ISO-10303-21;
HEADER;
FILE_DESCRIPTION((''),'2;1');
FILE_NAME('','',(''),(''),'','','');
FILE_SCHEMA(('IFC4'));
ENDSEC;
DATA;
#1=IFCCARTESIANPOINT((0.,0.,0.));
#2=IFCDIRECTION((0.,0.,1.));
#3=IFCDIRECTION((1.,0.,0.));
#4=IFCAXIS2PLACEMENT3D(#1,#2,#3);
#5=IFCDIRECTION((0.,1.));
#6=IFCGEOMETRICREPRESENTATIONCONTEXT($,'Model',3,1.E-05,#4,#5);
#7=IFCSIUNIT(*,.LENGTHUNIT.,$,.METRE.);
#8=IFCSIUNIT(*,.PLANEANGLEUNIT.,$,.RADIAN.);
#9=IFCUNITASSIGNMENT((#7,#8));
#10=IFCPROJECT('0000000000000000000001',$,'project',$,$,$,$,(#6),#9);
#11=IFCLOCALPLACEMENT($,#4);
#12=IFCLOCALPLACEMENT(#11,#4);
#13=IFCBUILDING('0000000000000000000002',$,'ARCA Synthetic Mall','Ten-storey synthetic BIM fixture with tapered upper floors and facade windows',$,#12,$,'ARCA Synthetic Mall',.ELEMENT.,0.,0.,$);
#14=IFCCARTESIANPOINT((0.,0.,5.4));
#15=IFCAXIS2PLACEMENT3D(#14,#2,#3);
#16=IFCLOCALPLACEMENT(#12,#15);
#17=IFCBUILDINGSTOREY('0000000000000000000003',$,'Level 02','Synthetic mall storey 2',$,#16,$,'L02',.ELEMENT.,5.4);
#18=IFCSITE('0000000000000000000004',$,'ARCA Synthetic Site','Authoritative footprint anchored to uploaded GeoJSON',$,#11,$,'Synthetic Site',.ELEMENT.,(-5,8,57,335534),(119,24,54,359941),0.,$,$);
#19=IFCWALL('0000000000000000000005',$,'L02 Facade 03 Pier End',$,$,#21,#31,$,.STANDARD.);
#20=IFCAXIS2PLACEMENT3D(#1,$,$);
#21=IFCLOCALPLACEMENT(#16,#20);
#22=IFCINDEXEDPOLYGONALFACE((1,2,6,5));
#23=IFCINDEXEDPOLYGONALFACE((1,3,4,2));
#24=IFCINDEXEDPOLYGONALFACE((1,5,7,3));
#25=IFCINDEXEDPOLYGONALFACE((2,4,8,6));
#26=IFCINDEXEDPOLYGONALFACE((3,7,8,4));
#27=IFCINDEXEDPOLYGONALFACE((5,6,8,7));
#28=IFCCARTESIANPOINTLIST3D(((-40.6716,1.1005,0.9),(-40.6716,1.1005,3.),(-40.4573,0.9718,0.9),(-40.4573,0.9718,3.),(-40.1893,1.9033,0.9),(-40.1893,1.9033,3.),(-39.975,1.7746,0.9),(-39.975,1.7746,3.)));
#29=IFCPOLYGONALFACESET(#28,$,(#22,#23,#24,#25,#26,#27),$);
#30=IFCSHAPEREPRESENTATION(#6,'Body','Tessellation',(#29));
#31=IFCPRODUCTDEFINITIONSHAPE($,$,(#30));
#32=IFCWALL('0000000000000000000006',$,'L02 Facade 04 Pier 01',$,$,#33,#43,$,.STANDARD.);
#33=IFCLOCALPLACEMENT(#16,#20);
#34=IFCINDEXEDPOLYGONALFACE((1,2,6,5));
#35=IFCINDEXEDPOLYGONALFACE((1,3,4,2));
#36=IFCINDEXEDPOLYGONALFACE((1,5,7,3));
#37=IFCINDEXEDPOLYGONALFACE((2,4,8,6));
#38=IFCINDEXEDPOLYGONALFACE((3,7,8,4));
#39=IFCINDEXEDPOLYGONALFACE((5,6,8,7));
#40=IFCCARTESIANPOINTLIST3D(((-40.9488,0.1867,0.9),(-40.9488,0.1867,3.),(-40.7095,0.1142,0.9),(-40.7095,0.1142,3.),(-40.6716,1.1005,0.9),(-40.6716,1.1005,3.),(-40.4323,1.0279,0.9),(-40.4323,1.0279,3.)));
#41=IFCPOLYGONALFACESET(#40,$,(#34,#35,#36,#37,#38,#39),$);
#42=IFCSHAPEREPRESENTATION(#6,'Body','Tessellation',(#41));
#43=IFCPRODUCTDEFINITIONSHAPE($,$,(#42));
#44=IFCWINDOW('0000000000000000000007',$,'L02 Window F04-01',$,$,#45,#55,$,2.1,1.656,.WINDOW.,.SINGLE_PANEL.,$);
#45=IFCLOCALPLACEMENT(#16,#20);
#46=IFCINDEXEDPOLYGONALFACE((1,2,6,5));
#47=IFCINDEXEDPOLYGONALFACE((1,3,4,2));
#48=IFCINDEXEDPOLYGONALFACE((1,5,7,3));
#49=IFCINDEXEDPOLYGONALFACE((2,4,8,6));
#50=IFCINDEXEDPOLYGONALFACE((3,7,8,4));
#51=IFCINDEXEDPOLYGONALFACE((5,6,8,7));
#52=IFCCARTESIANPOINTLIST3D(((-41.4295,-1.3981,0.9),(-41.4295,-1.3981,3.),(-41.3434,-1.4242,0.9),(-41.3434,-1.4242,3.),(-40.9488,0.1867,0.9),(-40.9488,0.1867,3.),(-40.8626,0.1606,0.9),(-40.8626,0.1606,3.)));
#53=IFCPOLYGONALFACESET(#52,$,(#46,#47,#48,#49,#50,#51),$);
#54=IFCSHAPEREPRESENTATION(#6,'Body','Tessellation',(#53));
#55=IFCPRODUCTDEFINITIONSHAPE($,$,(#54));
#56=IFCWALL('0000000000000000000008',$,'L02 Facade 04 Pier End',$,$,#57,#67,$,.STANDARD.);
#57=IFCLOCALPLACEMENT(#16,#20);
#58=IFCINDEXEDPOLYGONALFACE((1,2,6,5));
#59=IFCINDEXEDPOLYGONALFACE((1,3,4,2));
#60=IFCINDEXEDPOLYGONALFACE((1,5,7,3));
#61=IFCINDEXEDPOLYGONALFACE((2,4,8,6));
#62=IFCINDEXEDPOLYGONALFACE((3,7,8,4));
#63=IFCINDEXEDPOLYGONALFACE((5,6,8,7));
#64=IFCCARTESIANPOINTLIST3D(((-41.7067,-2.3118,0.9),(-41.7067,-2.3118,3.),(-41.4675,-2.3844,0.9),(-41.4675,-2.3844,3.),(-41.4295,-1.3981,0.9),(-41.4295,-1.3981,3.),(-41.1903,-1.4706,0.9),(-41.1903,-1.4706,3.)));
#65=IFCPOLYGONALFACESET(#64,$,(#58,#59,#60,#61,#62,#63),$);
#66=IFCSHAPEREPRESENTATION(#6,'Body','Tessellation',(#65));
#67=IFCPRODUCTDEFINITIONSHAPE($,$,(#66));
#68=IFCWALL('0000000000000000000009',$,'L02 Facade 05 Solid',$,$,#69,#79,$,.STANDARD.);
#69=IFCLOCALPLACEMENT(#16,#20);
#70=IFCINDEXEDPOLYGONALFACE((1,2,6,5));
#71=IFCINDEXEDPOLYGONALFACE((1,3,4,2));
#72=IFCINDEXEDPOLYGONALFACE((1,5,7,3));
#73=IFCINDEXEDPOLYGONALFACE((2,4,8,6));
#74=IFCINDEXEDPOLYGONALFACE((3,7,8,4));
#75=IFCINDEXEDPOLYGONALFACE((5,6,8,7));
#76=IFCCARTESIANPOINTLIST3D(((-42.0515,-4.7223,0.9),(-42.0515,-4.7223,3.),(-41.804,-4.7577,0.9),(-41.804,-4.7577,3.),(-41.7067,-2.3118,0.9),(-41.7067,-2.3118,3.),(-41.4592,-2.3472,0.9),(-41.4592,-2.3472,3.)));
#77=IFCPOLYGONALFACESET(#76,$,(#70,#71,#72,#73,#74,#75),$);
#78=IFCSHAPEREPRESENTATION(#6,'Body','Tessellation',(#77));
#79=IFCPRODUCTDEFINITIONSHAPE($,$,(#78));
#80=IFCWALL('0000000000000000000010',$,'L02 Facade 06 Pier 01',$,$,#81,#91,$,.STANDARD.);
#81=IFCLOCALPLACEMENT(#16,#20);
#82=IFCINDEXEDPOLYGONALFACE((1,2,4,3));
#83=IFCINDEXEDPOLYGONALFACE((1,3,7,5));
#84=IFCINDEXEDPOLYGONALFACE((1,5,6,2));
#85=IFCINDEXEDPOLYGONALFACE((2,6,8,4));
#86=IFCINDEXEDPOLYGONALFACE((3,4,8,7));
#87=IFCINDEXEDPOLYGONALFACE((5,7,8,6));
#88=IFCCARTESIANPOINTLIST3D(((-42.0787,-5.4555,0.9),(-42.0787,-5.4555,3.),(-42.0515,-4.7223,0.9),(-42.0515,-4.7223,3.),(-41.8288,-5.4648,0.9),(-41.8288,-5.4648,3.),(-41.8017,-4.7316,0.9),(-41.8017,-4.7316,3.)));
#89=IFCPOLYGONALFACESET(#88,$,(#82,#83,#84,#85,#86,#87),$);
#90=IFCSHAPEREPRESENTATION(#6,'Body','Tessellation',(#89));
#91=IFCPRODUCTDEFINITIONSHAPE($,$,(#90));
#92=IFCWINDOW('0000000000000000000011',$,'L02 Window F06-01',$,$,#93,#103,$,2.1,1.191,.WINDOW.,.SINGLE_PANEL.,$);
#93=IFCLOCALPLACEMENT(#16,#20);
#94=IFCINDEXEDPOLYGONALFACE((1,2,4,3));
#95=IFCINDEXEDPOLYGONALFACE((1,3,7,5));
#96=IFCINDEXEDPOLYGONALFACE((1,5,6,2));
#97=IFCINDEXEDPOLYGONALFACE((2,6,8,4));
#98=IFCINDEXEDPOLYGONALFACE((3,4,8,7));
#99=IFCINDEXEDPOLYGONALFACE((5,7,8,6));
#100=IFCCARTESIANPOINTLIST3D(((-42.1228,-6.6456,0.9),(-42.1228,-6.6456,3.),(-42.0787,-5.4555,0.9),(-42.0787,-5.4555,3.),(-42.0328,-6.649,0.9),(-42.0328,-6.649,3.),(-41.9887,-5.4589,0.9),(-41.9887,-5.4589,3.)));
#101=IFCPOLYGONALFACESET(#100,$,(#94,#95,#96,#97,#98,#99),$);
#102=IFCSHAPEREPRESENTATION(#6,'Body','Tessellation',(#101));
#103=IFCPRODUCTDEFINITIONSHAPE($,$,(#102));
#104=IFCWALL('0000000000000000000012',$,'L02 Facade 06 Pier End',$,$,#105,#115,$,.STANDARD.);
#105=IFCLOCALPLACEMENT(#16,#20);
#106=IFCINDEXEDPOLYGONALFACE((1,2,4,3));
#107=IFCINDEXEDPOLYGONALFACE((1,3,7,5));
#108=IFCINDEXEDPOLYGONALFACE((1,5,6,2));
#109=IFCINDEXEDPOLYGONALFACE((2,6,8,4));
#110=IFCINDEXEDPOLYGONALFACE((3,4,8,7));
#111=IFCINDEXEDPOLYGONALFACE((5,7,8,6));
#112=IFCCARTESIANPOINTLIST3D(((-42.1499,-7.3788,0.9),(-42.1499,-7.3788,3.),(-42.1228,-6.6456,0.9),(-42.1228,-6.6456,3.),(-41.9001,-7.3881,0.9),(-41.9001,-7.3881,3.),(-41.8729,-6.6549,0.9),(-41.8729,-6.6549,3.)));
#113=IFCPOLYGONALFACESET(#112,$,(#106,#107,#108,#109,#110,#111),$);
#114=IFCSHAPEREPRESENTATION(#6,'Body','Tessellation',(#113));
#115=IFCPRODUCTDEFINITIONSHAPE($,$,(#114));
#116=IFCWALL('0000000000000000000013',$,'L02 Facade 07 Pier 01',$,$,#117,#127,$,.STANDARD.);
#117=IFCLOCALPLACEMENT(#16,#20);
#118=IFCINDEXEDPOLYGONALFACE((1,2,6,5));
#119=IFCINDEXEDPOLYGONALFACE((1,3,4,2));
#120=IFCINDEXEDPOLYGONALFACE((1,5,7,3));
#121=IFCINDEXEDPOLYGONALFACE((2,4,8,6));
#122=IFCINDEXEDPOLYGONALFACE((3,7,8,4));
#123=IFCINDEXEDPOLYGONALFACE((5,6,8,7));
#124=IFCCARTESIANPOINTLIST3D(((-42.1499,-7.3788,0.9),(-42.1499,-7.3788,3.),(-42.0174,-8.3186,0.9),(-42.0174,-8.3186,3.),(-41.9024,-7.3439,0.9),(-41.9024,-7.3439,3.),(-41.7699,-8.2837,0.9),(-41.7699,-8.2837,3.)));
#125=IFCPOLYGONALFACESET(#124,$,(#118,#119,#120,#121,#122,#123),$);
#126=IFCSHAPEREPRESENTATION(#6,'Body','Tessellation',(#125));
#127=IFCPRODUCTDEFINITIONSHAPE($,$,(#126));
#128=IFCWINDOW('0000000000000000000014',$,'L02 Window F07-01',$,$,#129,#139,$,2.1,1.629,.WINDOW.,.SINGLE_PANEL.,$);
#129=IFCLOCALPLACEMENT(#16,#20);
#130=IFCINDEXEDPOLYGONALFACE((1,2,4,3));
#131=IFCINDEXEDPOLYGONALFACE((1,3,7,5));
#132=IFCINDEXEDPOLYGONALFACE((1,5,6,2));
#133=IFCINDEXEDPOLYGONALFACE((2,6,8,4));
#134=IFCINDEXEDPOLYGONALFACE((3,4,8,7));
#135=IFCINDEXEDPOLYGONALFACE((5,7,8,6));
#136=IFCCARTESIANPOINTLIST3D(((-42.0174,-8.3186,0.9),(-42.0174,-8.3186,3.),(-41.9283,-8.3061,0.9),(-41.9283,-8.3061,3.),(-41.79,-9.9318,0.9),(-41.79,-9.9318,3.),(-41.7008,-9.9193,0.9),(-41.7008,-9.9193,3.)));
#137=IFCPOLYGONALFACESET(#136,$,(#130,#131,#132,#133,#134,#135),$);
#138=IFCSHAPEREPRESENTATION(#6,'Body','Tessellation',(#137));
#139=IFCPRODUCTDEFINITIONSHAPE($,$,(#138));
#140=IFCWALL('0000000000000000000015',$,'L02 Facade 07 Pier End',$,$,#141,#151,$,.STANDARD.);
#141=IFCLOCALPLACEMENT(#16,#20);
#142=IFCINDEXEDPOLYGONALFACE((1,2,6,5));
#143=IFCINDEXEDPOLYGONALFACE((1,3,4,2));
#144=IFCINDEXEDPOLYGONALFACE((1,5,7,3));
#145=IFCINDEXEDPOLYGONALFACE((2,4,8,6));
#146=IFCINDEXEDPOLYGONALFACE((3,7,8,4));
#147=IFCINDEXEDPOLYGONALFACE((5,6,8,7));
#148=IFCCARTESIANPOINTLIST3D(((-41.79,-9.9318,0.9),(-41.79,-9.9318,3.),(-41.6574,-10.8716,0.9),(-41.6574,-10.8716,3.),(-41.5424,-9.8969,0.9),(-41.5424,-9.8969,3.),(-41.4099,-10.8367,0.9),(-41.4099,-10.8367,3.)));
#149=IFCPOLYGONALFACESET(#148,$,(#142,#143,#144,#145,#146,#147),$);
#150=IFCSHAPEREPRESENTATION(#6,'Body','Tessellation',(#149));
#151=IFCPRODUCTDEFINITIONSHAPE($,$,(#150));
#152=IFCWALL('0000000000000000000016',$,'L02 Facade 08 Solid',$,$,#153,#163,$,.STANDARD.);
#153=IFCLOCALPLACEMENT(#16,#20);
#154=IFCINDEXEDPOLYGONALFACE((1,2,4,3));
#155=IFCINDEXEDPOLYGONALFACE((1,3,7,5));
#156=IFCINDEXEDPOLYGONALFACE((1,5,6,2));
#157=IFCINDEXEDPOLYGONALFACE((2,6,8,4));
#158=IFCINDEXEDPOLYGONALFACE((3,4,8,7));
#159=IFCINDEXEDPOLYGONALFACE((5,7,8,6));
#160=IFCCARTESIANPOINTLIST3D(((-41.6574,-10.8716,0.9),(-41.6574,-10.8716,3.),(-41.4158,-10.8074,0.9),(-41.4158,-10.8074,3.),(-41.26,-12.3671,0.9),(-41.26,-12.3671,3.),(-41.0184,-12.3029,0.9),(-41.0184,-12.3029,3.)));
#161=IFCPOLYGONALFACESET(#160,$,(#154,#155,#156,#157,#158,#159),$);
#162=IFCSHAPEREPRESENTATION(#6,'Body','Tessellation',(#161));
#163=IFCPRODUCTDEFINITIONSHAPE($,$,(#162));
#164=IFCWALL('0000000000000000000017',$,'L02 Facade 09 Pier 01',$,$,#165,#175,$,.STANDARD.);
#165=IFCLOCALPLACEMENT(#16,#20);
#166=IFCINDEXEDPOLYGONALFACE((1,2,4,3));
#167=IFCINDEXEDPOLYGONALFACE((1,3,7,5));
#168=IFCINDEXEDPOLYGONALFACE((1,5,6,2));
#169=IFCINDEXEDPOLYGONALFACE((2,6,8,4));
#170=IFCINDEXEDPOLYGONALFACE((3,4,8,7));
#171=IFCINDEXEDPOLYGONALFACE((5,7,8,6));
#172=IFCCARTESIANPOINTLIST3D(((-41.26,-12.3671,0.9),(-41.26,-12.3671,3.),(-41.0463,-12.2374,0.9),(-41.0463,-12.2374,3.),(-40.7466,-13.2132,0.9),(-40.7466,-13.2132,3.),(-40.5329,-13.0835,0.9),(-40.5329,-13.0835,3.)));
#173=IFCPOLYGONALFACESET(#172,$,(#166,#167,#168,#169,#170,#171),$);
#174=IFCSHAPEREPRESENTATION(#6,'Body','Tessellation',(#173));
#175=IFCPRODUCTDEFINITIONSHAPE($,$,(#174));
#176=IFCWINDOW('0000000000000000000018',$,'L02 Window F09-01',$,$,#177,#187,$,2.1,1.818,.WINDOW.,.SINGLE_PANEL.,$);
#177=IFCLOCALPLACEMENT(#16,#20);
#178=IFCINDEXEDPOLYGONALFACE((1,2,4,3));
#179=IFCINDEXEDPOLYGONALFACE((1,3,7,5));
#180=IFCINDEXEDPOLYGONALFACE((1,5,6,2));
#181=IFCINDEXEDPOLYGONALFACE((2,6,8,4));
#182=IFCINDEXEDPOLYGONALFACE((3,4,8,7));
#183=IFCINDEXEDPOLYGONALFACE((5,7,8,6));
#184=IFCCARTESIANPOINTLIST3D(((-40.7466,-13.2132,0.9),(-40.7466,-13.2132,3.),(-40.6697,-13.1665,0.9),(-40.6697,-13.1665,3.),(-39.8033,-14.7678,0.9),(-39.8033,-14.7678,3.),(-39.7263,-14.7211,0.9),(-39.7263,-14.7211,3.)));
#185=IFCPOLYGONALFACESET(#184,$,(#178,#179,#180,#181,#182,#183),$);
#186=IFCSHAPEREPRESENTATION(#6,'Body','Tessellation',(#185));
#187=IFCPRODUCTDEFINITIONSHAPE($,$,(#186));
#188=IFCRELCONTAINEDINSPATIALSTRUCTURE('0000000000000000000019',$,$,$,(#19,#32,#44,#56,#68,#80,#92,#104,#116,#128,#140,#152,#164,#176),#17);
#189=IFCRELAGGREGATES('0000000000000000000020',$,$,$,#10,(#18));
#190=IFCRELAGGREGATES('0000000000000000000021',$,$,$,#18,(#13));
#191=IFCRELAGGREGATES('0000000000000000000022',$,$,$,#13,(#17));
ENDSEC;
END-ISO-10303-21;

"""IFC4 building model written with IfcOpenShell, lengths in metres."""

from ifc_helpers import new_model, si_unit, direction, frame, origin_with_axes, place, context, project, spatial, polyline, outline, extrude, element, save


model = new_model("IFC4")

# Units and contexts
model_context = context("Model", 3, precision=1e-05, world=origin_with_axes(), true_north=direction((0.0, 1.0)))
ifc_project = project(units=[si_unit("LENGTHUNIT", "METRE"), si_unit("PLANEANGLEUNIT", "RADIAN")], contexts=[model_context])

# Site, building, storey
site_placement = place(None, origin_with_axes())
site = spatial("IfcSite", under=ifc_project, at=site_placement, Name="ARCA Synthetic Site", Description="Authoritative footprint anchored to uploaded GeoJSON", LongName="Synthetic Site", CompositionType="ELEMENT", RefLatitude=(-5, 8, 57, 335534), RefLongitude=(119, 24, 54, 359941), RefElevation=0.0)
building_placement = place(site_placement, origin_with_axes())
building = spatial("IfcBuilding", under=site, at=building_placement, Name="ARCA Synthetic Mall", Description="Ten-storey synthetic BIM fixture with tapered upper floors and facade windows", LongName="ARCA Synthetic Mall", CompositionType="ELEMENT", ElevationOfRefHeight=0.0, ElevationOfTerrain=0.0)
storey_placement = place(building_placement, frame((0.0, 0.0, 5.4), z_axis=(0.0, 0.0, 1.0), x_axis=(1.0, 0.0, 0.0)))
storey = spatial("IfcBuildingStorey", under=building, at=storey_placement, Name="Level 02", Description="Synthetic mall storey 2", LongName="L02", CompositionType="ELEMENT", Elevation=5.4)

# Walls
wall_1_placement = place(storey_placement, frame((0.0, 0.0, 0.9), z_axis=(0.0, 0.0, 1.0), x_axis=(1.0, 0.0, 0.0)))
element("IfcWall", 1, at=wall_1_placement, inside=storey, Name="L02 Facade 03 Pier End", PredefinedType="STANDARD", context=model_context, shape_type="SweptSolid", body=[
    extrude(outline(polyline([(-40.1893, 1.9033), (-40.6716, 1.1005), (-40.4573, 0.9718), (-39.975, 1.7746), (-40.1893, 1.9033)])), origin_with_axes(), (0.0, 0.0, 1.0), 2.1),
])
wall_2_placement = place(storey_placement, frame((0.0, 0.0, 0.9), z_axis=(0.0, 0.0, 1.0), x_axis=(1.0, 0.0, 0.0)))
element("IfcWall", 2, at=wall_2_placement, inside=storey, Name="L02 Facade 04 Pier 01", PredefinedType="STANDARD", context=model_context, shape_type="SweptSolid", body=[
    extrude(outline(polyline([(-40.6716, 1.1005), (-40.9488, 0.1867), (-40.7095, 0.1142), (-40.4323, 1.0279), (-40.6716, 1.1005)])), origin_with_axes(), (0.0, 0.0, 1.0), 2.1),
])

# Window
window_1_placement = place(storey_placement, frame((0.0, 0.0, 0.9), z_axis=(0.0, 0.0, 1.0), x_axis=(1.0, 0.0, 0.0)))
element("IfcWindow", 3, at=window_1_placement, inside=storey, Name="L02 Window F04-01", OverallHeight=2.1, OverallWidth=1.656, PartitioningType="SINGLE_PANEL", PredefinedType="WINDOW", context=model_context, shape_type="SweptSolid", body=[
    extrude(outline(polyline([(-40.9488, 0.1867), (-41.4295, -1.3981), (-41.3434, -1.4242), (-40.8626, 0.1606), (-40.9488, 0.1867)])), origin_with_axes(), (0.0, 0.0, 1.0), 2.1),
])

# Walls
wall_3_placement = place(storey_placement, frame((0.0, 0.0, 0.9), z_axis=(0.0, 0.0, 1.0), x_axis=(1.0, 0.0, 0.0)))
element("IfcWall", 4, at=wall_3_placement, inside=storey, Name="L02 Facade 04 Pier End", PredefinedType="STANDARD", context=model_context, shape_type="SweptSolid", body=[
    extrude(outline(polyline([(-41.4295, -1.3981), (-41.7067, -2.3118), (-41.4675, -2.3844), (-41.1903, -1.4706), (-41.4295, -1.3981)])), origin_with_axes(), (0.0, 0.0, 1.0), 2.1),
])
wall_4_placement = place(storey_placement, frame((0.0, 0.0, 0.9), z_axis=(0.0, 0.0, 1.0), x_axis=(1.0, 0.0, 0.0)))
element("IfcWall", 5, at=wall_4_placement, inside=storey, Name="L02 Facade 05 Solid", PredefinedType="STANDARD", context=model_context, shape_type="SweptSolid", body=[
    extrude(outline(polyline([(-41.7067, -2.3118), (-42.0515, -4.7223), (-41.804, -4.7577), (-41.4592, -2.3472), (-41.7067, -2.3118)])), origin_with_axes(), (0.0, 0.0, 1.0), 2.1),
])
wall_5_placement = place(storey_placement, frame((0.0, 0.0, 0.9), z_axis=(0.0, 0.0, 1.0), x_axis=(1.0, 0.0, 0.0)))
element("IfcWall", 6, at=wall_5_placement, inside=storey, Name="L02 Facade 06 Pier 01", PredefinedType="STANDARD", context=model_context, shape_type="SweptSolid", body=[
    extrude(outline(polyline([(-42.0515, -4.7223), (-42.0787, -5.4555), (-41.8288, -5.4648), (-41.8017, -4.7316), (-42.0515, -4.7223)])), origin_with_axes(), (0.0, 0.0, 1.0), 2.1),
])

# Window
window_2_placement = place(storey_placement, frame((0.0, 0.0, 0.9), z_axis=(0.0, 0.0, 1.0), x_axis=(1.0, 0.0, 0.0)))
element("IfcWindow", 7, at=window_2_placement, inside=storey, Name="L02 Window F06-01", OverallHeight=2.1, OverallWidth=1.191, PartitioningType="SINGLE_PANEL", PredefinedType="WINDOW", context=model_context, shape_type="SweptSolid", body=[
    extrude(outline(polyline([(-42.0787, -5.4555), (-42.1228, -6.6456), (-42.0328, -6.649), (-41.9887, -5.4589), (-42.0787, -5.4555)])), origin_with_axes(), (0.0, 0.0, 1.0), 2.1),
])

# Walls
wall_6_placement = place(storey_placement, frame((0.0, 0.0, 0.9), z_axis=(0.0, 0.0, 1.0), x_axis=(1.0, 0.0, 0.0)))
element("IfcWall", 8, at=wall_6_placement, inside=storey, Name="L02 Facade 06 Pier End", PredefinedType="STANDARD", context=model_context, shape_type="SweptSolid", body=[
    extrude(outline(polyline([(-42.1228, -6.6456), (-42.1499, -7.3788), (-41.9001, -7.3881), (-41.8729, -6.6549), (-42.1228, -6.6456)])), origin_with_axes(), (0.0, 0.0, 1.0), 2.1),
])
wall_7_placement = place(storey_placement, frame((0.0, 0.0, 0.9), z_axis=(0.0, 0.0, 1.0), x_axis=(1.0, 0.0, 0.0)))
element("IfcWall", 9, at=wall_7_placement, inside=storey, Name="L02 Facade 07 Pier 01", PredefinedType="STANDARD", context=model_context, shape_type="SweptSolid", body=[
    extrude(outline(polyline([(-42.1499, -7.3788), (-42.0174, -8.3186), (-41.7699, -8.2837), (-41.9024, -7.3439), (-42.1499, -7.3788)])), origin_with_axes(), (0.0, 0.0, 1.0), 2.1),
])

# Window
window_3_placement = place(storey_placement, frame((0.0, 0.0, 0.9), z_axis=(0.0, 0.0, 1.0), x_axis=(1.0, 0.0, 0.0)))
element("IfcWindow", 10, at=window_3_placement, inside=storey, Name="L02 Window F07-01", OverallHeight=2.1, OverallWidth=1.629, PartitioningType="SINGLE_PANEL", PredefinedType="WINDOW", context=model_context, shape_type="SweptSolid", body=[
    extrude(outline(polyline([(-42.0174, -8.3186), (-41.79, -9.9318), (-41.7008, -9.9193), (-41.9283, -8.3061), (-42.0174, -8.3186)])), origin_with_axes(), (0.0, 0.0, 1.0), 2.1),
])

# Walls
wall_8_placement = place(storey_placement, frame((0.0, 0.0, 0.9), z_axis=(0.0, 0.0, 1.0), x_axis=(1.0, 0.0, 0.0)))
element("IfcWall", 11, at=wall_8_placement, inside=storey, Name="L02 Facade 07 Pier End", PredefinedType="STANDARD", context=model_context, shape_type="SweptSolid", body=[
    extrude(outline(polyline([(-41.79, -9.9318), (-41.6574, -10.8716), (-41.4099, -10.8367), (-41.5424, -9.8969), (-41.79, -9.9318)])), origin_with_axes(), (0.0, 0.0, 1.0), 2.1),
])
wall_9_placement = place(storey_placement, frame((0.0, 0.0, 0.9), z_axis=(0.0, 0.0, 1.0), x_axis=(1.0, 0.0, 0.0)))
element("IfcWall", 12, at=wall_9_placement, inside=storey, Name="L02 Facade 08 Solid", PredefinedType="STANDARD", context=model_context, shape_type="SweptSolid", body=[
    extrude(outline(polyline([(-41.6574, -10.8716), (-41.26, -12.3671), (-41.0184, -12.3029), (-41.4158, -10.8074), (-41.6574, -10.8716)])), origin_with_axes(), (0.0, 0.0, 1.0), 2.1),
])
wall_10_placement = place(storey_placement, frame((0.0, 0.0, 0.9), z_axis=(0.0, 0.0, 1.0), x_axis=(1.0, 0.0, 0.0)))
element("IfcWall", 13, at=wall_10_placement, inside=storey, Name="L02 Facade 09 Pier 01", PredefinedType="STANDARD", context=model_context, shape_type="SweptSolid", body=[
    extrude(outline(polyline([(-41.26, -12.3671), (-40.7466, -13.2132), (-40.5329, -13.0835), (-41.0463, -12.2374), (-41.26, -12.3671)])), origin_with_axes(), (0.0, 0.0, 1.0), 2.1),
])

# Window
window_4_placement = place(storey_placement, frame((0.0, 0.0, 0.9), z_axis=(0.0, 0.0, 1.0), x_axis=(1.0, 0.0, 0.0)))
element("IfcWindow", 14, at=window_4_placement, inside=storey, Name="L02 Window F09-01", OverallHeight=2.1, OverallWidth=1.818, PartitioningType="SINGLE_PANEL", PredefinedType="WINDOW", context=model_context, shape_type="SweptSolid", body=[
    extrude(outline(polyline([(-40.7466, -13.2132), (-39.8033, -14.7678), (-39.7263, -14.7211), (-40.6697, -13.1665), (-40.7466, -13.2132)])), origin_with_axes(), (0.0, 0.0, 1.0), 2.1),
])

save(model, "model.ifc")
